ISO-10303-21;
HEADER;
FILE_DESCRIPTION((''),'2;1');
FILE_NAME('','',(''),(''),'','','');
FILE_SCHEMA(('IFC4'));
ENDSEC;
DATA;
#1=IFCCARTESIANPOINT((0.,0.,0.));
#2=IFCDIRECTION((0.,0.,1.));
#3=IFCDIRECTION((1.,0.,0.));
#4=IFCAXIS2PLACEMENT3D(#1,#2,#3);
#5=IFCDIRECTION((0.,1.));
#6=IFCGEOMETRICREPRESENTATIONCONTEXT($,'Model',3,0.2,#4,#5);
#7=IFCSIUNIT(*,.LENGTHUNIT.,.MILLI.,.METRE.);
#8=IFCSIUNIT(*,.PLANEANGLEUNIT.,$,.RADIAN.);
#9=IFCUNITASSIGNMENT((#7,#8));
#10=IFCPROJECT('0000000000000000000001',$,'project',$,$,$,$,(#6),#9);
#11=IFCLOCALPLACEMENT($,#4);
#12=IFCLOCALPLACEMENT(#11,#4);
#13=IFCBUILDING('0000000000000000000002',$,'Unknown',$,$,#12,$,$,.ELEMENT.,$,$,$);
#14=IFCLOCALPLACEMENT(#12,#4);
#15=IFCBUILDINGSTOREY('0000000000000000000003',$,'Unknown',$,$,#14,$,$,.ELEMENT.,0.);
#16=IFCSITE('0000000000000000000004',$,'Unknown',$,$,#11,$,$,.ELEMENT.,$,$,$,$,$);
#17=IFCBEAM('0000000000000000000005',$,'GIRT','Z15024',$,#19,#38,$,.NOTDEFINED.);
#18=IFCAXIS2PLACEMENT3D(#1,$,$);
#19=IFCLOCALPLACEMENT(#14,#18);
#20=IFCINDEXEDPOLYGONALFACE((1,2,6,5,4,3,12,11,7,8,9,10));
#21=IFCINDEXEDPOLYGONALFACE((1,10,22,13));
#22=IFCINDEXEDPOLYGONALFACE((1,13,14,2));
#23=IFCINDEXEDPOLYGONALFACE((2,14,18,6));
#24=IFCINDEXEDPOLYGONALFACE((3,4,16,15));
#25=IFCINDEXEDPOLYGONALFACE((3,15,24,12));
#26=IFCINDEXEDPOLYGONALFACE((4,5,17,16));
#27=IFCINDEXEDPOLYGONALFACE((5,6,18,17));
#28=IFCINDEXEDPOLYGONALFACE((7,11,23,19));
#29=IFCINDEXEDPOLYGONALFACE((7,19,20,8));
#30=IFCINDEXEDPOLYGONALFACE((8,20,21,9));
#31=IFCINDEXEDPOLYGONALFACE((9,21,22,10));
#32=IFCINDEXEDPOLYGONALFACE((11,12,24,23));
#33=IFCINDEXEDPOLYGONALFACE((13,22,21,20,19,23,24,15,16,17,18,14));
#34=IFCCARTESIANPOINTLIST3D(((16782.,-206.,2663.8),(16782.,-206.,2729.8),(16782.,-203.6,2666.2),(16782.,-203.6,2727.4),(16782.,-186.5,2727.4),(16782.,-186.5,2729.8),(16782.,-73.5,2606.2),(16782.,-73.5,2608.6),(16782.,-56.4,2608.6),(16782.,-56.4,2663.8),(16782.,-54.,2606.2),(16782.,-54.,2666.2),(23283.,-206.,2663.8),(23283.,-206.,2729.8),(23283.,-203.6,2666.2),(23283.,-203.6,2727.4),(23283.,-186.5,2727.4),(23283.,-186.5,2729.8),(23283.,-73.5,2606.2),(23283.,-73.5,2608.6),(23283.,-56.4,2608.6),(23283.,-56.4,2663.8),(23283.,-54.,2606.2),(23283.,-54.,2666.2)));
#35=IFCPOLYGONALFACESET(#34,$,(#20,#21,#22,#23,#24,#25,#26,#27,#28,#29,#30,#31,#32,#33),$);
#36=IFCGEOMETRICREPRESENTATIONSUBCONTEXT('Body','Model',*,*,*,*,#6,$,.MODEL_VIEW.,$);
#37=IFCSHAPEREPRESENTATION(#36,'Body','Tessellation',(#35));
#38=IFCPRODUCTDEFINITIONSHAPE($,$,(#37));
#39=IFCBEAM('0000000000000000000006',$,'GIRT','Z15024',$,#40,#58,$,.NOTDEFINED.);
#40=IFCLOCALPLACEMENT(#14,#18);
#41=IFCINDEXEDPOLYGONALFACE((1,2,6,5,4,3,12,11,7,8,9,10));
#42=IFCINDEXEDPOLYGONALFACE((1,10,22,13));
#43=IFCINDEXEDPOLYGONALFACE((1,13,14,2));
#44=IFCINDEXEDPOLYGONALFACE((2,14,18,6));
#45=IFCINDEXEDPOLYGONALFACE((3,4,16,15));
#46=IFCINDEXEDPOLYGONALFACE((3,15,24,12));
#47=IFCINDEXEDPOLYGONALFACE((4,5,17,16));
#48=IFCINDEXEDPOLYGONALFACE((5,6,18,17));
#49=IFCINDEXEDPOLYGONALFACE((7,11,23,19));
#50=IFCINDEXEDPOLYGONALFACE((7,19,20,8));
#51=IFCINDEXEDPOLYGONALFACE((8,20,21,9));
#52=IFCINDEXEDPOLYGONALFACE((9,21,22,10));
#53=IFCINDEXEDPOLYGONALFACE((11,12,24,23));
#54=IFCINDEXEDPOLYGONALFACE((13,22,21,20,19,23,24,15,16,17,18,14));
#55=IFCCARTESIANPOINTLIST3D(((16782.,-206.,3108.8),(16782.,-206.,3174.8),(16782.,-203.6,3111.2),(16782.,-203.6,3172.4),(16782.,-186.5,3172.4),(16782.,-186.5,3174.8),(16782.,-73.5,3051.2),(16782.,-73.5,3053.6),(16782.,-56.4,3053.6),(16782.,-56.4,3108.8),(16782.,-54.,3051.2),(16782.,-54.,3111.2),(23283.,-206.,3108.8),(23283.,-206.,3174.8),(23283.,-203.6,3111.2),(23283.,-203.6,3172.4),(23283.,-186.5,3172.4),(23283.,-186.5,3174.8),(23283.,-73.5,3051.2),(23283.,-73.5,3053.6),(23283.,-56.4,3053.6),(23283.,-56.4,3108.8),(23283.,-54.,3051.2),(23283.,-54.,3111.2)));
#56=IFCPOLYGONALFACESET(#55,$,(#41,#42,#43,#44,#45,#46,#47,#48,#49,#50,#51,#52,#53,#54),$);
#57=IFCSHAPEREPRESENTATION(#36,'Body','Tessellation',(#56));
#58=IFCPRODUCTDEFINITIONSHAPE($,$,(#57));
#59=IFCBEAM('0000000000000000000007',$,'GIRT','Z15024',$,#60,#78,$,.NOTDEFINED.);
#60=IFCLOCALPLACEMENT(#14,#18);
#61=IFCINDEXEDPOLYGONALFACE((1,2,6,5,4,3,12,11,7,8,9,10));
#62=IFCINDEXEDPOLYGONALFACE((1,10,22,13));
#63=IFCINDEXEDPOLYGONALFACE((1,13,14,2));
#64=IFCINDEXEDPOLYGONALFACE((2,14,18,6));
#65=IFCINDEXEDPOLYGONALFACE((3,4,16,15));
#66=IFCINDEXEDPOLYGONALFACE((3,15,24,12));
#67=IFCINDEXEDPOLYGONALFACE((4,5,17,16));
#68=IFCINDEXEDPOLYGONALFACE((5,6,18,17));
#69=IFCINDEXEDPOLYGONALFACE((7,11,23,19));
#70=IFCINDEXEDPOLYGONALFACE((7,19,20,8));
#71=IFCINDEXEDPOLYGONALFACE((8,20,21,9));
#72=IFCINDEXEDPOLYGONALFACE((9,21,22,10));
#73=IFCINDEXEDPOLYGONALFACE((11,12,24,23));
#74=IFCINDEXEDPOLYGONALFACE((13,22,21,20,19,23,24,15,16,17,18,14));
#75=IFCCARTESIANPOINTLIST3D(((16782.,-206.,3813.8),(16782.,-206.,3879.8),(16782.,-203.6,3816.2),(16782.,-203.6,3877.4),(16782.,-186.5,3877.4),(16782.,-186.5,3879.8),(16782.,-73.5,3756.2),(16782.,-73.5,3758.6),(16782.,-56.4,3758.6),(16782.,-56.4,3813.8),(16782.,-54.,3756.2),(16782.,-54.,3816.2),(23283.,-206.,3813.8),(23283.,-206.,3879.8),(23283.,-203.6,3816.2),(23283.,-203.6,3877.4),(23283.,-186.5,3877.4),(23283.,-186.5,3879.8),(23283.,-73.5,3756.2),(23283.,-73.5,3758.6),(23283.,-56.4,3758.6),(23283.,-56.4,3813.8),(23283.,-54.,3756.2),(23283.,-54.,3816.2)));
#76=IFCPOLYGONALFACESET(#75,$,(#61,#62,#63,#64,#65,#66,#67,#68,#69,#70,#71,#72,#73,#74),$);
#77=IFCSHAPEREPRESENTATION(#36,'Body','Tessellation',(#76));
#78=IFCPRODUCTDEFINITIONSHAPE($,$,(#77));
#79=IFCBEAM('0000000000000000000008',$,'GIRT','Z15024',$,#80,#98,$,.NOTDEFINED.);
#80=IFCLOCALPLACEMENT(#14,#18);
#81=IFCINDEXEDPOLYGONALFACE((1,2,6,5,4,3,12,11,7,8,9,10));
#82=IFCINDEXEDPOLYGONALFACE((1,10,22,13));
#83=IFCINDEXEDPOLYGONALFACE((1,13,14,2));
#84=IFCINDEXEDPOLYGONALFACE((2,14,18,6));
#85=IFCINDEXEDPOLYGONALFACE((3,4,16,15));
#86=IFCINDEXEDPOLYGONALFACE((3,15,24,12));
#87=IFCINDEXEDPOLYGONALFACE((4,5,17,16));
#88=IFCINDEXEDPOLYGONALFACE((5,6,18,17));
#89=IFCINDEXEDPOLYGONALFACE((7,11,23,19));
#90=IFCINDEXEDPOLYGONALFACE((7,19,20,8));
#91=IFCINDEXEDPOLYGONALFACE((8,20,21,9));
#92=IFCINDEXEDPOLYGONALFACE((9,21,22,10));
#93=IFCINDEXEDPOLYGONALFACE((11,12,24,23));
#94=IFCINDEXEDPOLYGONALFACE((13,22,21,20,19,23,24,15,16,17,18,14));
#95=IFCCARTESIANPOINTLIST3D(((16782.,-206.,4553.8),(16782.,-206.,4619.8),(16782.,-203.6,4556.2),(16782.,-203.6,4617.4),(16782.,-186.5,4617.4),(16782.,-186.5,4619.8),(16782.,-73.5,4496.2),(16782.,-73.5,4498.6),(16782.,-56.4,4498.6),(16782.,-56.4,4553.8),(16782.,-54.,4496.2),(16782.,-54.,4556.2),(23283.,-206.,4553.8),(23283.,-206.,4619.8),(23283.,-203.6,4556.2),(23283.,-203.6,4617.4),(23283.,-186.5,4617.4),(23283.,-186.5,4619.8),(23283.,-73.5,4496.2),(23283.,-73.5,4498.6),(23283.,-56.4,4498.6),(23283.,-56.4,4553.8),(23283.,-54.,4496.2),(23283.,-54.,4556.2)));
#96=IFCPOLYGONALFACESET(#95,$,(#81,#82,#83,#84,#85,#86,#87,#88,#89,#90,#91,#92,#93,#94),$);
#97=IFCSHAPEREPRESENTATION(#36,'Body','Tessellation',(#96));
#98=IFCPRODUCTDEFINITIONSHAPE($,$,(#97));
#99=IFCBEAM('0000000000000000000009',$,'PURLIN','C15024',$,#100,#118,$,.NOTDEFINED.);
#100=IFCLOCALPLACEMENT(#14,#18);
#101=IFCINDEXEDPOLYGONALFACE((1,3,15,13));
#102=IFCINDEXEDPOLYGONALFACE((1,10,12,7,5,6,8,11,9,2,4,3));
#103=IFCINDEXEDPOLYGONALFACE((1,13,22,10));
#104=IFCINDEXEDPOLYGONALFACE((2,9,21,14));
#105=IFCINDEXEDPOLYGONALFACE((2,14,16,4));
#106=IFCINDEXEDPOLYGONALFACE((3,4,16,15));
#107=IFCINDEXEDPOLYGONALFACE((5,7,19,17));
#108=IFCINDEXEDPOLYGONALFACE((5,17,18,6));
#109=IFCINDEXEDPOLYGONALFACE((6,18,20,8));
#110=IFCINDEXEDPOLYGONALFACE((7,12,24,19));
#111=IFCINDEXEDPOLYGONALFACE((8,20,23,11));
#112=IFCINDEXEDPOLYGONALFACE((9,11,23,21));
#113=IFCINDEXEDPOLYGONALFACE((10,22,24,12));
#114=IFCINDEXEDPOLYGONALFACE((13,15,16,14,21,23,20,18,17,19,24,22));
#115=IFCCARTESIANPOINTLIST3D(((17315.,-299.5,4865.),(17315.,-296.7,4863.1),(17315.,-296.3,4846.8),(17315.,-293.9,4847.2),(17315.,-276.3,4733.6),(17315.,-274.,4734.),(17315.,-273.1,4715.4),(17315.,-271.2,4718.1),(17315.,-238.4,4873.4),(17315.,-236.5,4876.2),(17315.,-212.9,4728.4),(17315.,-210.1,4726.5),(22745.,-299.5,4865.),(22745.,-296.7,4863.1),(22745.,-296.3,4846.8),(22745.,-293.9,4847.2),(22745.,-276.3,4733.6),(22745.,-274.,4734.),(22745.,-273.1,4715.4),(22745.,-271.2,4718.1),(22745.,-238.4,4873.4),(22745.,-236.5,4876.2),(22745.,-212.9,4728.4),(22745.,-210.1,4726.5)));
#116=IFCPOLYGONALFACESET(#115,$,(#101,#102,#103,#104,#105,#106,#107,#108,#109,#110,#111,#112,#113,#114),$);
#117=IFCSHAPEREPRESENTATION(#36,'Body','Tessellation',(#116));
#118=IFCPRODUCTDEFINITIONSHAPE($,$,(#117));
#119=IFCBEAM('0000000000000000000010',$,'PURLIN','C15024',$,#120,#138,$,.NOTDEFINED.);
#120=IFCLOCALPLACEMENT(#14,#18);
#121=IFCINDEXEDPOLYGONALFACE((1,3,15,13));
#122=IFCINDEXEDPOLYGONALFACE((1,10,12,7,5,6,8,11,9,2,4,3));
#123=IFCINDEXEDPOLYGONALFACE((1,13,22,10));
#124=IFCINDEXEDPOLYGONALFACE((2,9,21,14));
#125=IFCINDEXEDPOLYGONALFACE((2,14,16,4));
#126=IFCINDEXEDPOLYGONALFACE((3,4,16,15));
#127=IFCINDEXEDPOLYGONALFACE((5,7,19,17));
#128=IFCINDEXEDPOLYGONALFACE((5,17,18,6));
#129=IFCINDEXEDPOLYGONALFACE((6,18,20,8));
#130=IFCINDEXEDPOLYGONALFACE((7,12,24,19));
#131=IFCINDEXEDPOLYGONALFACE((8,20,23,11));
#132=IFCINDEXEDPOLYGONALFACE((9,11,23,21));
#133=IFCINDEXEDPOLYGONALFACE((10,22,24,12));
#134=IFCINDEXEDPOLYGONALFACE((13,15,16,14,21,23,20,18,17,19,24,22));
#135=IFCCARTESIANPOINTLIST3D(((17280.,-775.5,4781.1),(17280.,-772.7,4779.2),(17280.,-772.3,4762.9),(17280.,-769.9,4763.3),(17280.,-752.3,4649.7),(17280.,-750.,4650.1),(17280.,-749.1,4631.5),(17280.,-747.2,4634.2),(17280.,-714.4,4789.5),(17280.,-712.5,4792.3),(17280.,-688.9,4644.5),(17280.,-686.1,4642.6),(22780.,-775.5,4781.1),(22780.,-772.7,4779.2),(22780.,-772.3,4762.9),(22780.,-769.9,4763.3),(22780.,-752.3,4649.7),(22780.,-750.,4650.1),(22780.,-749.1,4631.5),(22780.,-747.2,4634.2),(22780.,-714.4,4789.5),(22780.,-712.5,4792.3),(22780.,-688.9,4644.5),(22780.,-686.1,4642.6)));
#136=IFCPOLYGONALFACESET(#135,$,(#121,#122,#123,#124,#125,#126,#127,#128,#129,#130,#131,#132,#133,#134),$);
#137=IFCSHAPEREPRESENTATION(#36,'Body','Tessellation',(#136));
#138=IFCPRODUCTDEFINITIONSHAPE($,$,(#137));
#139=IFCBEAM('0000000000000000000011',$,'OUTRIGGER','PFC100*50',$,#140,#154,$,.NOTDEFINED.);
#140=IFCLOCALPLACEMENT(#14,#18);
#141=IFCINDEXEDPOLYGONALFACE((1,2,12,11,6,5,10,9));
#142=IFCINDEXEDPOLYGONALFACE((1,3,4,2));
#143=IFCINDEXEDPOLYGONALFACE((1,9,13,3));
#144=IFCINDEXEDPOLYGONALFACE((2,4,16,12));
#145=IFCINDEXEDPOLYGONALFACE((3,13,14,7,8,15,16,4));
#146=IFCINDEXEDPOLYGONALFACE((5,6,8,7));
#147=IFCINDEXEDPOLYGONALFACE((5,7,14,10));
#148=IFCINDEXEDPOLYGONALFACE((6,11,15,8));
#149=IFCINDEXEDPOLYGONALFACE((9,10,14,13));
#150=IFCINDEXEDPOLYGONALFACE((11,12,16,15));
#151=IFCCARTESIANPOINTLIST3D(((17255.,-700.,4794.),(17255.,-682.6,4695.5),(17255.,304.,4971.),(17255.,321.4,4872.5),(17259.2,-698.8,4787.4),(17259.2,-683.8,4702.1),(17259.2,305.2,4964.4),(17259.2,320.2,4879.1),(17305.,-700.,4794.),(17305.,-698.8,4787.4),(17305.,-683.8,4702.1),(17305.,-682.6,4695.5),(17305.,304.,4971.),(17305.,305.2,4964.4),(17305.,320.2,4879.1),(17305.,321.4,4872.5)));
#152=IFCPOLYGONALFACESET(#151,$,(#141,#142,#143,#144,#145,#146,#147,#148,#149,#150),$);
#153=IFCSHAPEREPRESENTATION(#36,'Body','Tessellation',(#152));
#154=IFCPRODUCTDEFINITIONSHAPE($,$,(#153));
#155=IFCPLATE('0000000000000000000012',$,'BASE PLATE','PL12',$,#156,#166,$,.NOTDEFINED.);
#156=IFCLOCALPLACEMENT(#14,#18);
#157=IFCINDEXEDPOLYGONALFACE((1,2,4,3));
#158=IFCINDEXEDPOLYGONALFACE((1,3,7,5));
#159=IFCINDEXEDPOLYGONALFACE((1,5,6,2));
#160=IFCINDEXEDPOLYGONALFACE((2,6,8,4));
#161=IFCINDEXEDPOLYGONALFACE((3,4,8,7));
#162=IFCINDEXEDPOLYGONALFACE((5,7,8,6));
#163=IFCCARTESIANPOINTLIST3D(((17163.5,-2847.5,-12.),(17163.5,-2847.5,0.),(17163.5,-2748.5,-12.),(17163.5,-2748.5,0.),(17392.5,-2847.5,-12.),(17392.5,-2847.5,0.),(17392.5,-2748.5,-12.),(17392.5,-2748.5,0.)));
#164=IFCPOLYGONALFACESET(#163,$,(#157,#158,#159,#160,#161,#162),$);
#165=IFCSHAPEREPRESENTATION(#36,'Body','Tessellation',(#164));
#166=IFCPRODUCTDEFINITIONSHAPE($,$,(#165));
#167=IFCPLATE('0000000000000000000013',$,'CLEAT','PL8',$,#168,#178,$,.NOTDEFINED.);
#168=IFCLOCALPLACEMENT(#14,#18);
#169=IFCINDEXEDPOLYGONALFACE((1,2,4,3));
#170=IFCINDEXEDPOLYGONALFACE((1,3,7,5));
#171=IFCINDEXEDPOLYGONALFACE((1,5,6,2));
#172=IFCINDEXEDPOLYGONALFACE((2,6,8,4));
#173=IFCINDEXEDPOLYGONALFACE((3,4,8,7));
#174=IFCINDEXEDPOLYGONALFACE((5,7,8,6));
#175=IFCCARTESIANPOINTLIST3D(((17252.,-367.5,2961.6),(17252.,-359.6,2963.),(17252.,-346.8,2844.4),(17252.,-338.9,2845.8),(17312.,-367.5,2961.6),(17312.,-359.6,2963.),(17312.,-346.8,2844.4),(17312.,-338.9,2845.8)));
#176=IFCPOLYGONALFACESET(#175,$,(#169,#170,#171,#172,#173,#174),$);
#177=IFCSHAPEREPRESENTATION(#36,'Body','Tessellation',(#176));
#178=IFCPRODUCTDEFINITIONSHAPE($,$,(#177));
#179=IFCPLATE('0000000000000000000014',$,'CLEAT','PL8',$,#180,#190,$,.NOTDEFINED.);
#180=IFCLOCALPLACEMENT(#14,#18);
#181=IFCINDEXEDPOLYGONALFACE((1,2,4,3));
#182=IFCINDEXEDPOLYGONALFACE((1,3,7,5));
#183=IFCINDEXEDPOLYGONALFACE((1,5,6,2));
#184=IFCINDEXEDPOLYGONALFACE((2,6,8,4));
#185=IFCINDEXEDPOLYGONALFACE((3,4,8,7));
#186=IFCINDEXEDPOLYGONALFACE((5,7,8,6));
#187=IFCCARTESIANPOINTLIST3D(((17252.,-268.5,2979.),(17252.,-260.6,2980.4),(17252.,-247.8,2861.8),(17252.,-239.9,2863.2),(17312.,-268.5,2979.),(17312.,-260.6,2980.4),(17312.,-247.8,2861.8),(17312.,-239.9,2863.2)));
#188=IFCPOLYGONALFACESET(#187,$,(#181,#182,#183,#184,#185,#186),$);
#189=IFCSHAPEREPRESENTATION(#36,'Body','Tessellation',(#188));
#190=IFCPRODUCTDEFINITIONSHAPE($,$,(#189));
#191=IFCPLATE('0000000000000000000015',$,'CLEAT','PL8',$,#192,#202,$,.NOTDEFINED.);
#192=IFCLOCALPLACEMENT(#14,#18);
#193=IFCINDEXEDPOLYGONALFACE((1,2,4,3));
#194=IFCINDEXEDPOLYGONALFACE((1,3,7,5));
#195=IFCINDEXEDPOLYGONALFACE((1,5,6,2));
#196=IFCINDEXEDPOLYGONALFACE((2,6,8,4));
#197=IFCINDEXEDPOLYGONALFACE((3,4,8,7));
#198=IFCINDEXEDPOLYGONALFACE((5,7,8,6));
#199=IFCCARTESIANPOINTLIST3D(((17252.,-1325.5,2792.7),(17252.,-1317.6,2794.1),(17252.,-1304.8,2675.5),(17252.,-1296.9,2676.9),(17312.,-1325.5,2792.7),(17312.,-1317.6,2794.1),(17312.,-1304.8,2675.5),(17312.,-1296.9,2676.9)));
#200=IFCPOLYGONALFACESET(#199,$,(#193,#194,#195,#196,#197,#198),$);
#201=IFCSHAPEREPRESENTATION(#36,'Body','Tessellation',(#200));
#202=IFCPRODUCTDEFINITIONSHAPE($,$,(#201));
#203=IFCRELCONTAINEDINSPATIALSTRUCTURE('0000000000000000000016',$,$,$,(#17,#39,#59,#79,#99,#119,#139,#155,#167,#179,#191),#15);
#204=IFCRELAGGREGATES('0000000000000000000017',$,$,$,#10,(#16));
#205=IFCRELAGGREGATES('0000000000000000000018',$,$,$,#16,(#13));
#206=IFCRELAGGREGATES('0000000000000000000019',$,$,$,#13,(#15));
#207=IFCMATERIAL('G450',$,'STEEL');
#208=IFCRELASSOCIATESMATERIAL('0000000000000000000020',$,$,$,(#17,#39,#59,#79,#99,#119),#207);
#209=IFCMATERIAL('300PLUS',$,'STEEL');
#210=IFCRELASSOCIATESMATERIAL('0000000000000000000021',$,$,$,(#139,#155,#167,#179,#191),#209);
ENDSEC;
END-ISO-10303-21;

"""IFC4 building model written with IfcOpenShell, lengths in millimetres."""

from ifc_helpers import new_model, si_unit, direction, frame, origin_with_axes, place, context, subcontext, project, spatial, line, indexed_curve, outline, extrude, material, element, save


model = new_model("IFC4")

# Units and contexts
model_context = context("Model", 3, precision=0.2, world=origin_with_axes(), true_north=direction((0.0, 1.0)))
body_context = subcontext(model_context, "Body", "Model", "MODEL_VIEW")
ifc_project = project(units=[si_unit("LENGTHUNIT", "METRE", prefix="MILLI"), si_unit("PLANEANGLEUNIT", "RADIAN")], contexts=[model_context])

# Site, building, storey
site_placement = place(None, origin_with_axes())
site = spatial("IfcSite", under=ifc_project, at=site_placement, Name="Unknown", CompositionType="ELEMENT")
building_placement = place(site_placement, origin_with_axes())
building = spatial("IfcBuilding", under=site, at=building_placement, Name="Unknown", CompositionType="ELEMENT")
storey_placement = place(building_placement, origin_with_axes())
storey = spatial("IfcBuildingStorey", under=building, at=storey_placement, Name="Unknown", CompositionType="ELEMENT", Elevation=0.0)

# Shared definitions
ifc_material_1 = material(Name="G450", Category="STEEL")

# Beams
for number, where, z_axis, x_axis, name in (
    (1, (16782.0, -130.0, 2665.0), (0.0, 0.0, -1.0), (1.0, 0.0, 0.0), "GIRT"),
    (2, (16782.0, -130.0, 3110.0), (0.0, 0.0, -1.0), (1.0, 0.0, 0.0), "GIRT"),
    (3, (16782.0, -130.0, 3815.0), (0.0, 0.0, -1.0), (1.0, 0.0, 0.0), "GIRT"),
    (4, (16782.0, -130.0, 4555.0), (0.0, 0.0, -1.0), (1.0, 0.0, 0.0), "GIRT"),
):
    element("IfcBeam", number, at=place(storey_placement, frame(where, z_axis=z_axis, x_axis=x_axis)), inside=storey, material=ifc_material_1, Name=name, Description="Z15024", PredefinedType="NOTDEFINED", context=body_context, shape_type="SolidModel", body=[
        extrude(outline(indexed_curve([(58.8, -76.0), (58.8, -56.5), (56.4, -56.5), (56.4, -73.6), (1.2, -73.6), (1.2, 76.0), (-64.8, 76.0), (-64.8, 56.5), (-62.4, 56.5), (-62.4, 73.6), (-1.2, 73.6), (-1.2, -76.0)], segments=[line(1, 2, 3, 4, 5, 6, 7, 8, 9, 10, 11, 12, 1)])), frame((0.0, 0.0, 0.0), z_axis=(-1.0, 0.0, 0.0), x_axis=(0.0, 0.0, 1.0)), (0.0, 0.0, -1.0), 6501.0),
    ])
beam_1_placement = place(storey_placement, frame((17315.0, -254.8, 4795.8), z_axis=(0.0, -0.984808, -0.173648), x_axis=(1.0, 0.0, 0.0)))
element("IfcBeam", 5, at=beam_1_placement, inside=storey, material=ifc_material_1, Name="PURLIN", Description="C15024", PredefinedType="NOTDEFINED", context=body_context, shape_type="SolidModel", body=[
    extrude(outline(indexed_curve([(32.0, -76.0), (32.0, -57.5), (29.6, -57.5), (29.6, -73.6), (-29.6, -73.6), (-29.6, 73.6), (29.6, 73.6), (29.6, 57.5), (32.0, 57.5), (32.0, 76.0), (-32.0, 76.0), (-32.0, -76.0)], segments=[line(1, 2, 3, 4, 5, 6, 7, 8, 9, 10, 11, 12, 1)])), frame((0.0, 0.0, 0.0), z_axis=(-1.0, 0.0, 0.0), x_axis=(0.0, 0.0, 1.0)), (0.0, 0.0, -1.0), 5430.0),
])
beam_2_placement = place(storey_placement, frame((17280.0, -730.8, 4711.9), z_axis=(0.0, -0.984808, -0.173648), x_axis=(1.0, 0.0, 0.0)))
element("IfcBeam", 6, at=beam_2_placement, inside=storey, material=ifc_material_1, Name="PURLIN", Description="C15024", PredefinedType="NOTDEFINED", context=body_context, shape_type="SolidModel", body=[
    extrude(outline(indexed_curve([(32.0, -76.0), (32.0, -57.5), (29.6, -57.5), (29.6, -73.6), (-29.6, -73.6), (-29.6, 73.6), (29.6, 73.6), (29.6, 57.5), (32.0, 57.5), (32.0, 76.0), (-32.0, 76.0), (-32.0, -76.0)], segments=[line(1, 2, 3, 4, 5, 6, 7, 8, 9, 10, 11, 12, 1)])), frame((0.0, 0.0, 0.0), z_axis=(-1.0, 0.0, 0.0), x_axis=(0.0, 0.0, 1.0)), (0.0, 0.0, -1.0), 5500.0),
])
ifc_material_2 = material(Name="300PLUS", Category="STEEL")
beam_3_placement = place(storey_placement, frame((17280.0, -691.3, 4744.8), z_axis=(1.0, 0.0, 0.0), x_axis=(0.0, 0.984813, 0.173617)))
element("IfcBeam", 7, at=beam_3_placement, inside=storey, material=ifc_material_2, Name="OUTRIGGER", Description="PFC100*50", PredefinedType="NOTDEFINED", context=body_context, shape_type="SolidModel", body=[
    extrude(outline(indexed_curve([(-25.0, -50.0), (25.0, -50.0), (25.0, -43.3), (-20.8, -43.3), (-20.8, 43.3), (25.0, 43.3), (25.0, 50.0), (-25.0, 50.0)], segments=[line(1, 2, 3, 4, 5, 6, 7, 8, 1)])), frame((0.0, 0.0, 0.0), z_axis=(-1.0, 0.0, 0.0), x_axis=(0.0, 0.0, 1.0)), (0.0, 0.0, -1.0), 1019.5),
])

# Plates
plate_1_placement = place(storey_placement, frame((17163.5, -2847.5, -6.0), z_axis=(0.0, 0.0, 1.0), x_axis=(1.0, 0.0, 0.0)))
element("IfcPlate", 8, at=plate_1_placement, inside=storey, material=ifc_material_2, Name="BASE PLATE", Description="PL12", PredefinedType="NOTDEFINED", context=body_context, shape_type="SolidModel", body=[
    extrude(outline(indexed_curve([(0.0, 0.0), (229.0, 0.0), (229.0, 99.0), (0.0, 99.0)], segments=[line(1, 2, 3, 4, 1)])), frame((0.0, 0.0, 6.0), z_axis=(0.0, 0.0, 1.0), x_axis=(1.0, 0.0, 0.0)), (0.0, 0.0, -1.0), 12.0),
])
for number, where, z_axis, x_axis, name in (
    (9, (17312.0, -342.9, 2845.1), (0.0, 0.984758, 0.173929), (-1.0, 0.0, 0.0), "CLEAT"),
    (10, (17312.0, -243.9, 2862.5), (0.0, 0.984758, 0.173929), (-1.0, 0.0, 0.0), "CLEAT"),
    (11, (17312.0, -1300.9, 2676.2), (0.0, 0.984758, 0.173929), (-1.0, 0.0, 0.0), "CLEAT"),
):
    element("IfcPlate", number, at=place(storey_placement, frame(where, z_axis=z_axis, x_axis=x_axis)), inside=storey, material=ifc_material_2, Name=name, Description="PL8", PredefinedType="NOTDEFINED", context=body_context, shape_type="SolidModel", body=[
        extrude(outline(indexed_curve([(0.0, 0.0), (60.0, 0.0), (60.0, 119.0), (0.0, 119.0)], segments=[line(1, 2, 3, 4, 1)])), frame((0.0, 0.0, 4.0), z_axis=(0.0, 0.0, 1.0), x_axis=(1.0, 0.0, 0.0)), (0.0, 0.0, -1.0), 8.0),
    ])

save(model, "model.ifc")
